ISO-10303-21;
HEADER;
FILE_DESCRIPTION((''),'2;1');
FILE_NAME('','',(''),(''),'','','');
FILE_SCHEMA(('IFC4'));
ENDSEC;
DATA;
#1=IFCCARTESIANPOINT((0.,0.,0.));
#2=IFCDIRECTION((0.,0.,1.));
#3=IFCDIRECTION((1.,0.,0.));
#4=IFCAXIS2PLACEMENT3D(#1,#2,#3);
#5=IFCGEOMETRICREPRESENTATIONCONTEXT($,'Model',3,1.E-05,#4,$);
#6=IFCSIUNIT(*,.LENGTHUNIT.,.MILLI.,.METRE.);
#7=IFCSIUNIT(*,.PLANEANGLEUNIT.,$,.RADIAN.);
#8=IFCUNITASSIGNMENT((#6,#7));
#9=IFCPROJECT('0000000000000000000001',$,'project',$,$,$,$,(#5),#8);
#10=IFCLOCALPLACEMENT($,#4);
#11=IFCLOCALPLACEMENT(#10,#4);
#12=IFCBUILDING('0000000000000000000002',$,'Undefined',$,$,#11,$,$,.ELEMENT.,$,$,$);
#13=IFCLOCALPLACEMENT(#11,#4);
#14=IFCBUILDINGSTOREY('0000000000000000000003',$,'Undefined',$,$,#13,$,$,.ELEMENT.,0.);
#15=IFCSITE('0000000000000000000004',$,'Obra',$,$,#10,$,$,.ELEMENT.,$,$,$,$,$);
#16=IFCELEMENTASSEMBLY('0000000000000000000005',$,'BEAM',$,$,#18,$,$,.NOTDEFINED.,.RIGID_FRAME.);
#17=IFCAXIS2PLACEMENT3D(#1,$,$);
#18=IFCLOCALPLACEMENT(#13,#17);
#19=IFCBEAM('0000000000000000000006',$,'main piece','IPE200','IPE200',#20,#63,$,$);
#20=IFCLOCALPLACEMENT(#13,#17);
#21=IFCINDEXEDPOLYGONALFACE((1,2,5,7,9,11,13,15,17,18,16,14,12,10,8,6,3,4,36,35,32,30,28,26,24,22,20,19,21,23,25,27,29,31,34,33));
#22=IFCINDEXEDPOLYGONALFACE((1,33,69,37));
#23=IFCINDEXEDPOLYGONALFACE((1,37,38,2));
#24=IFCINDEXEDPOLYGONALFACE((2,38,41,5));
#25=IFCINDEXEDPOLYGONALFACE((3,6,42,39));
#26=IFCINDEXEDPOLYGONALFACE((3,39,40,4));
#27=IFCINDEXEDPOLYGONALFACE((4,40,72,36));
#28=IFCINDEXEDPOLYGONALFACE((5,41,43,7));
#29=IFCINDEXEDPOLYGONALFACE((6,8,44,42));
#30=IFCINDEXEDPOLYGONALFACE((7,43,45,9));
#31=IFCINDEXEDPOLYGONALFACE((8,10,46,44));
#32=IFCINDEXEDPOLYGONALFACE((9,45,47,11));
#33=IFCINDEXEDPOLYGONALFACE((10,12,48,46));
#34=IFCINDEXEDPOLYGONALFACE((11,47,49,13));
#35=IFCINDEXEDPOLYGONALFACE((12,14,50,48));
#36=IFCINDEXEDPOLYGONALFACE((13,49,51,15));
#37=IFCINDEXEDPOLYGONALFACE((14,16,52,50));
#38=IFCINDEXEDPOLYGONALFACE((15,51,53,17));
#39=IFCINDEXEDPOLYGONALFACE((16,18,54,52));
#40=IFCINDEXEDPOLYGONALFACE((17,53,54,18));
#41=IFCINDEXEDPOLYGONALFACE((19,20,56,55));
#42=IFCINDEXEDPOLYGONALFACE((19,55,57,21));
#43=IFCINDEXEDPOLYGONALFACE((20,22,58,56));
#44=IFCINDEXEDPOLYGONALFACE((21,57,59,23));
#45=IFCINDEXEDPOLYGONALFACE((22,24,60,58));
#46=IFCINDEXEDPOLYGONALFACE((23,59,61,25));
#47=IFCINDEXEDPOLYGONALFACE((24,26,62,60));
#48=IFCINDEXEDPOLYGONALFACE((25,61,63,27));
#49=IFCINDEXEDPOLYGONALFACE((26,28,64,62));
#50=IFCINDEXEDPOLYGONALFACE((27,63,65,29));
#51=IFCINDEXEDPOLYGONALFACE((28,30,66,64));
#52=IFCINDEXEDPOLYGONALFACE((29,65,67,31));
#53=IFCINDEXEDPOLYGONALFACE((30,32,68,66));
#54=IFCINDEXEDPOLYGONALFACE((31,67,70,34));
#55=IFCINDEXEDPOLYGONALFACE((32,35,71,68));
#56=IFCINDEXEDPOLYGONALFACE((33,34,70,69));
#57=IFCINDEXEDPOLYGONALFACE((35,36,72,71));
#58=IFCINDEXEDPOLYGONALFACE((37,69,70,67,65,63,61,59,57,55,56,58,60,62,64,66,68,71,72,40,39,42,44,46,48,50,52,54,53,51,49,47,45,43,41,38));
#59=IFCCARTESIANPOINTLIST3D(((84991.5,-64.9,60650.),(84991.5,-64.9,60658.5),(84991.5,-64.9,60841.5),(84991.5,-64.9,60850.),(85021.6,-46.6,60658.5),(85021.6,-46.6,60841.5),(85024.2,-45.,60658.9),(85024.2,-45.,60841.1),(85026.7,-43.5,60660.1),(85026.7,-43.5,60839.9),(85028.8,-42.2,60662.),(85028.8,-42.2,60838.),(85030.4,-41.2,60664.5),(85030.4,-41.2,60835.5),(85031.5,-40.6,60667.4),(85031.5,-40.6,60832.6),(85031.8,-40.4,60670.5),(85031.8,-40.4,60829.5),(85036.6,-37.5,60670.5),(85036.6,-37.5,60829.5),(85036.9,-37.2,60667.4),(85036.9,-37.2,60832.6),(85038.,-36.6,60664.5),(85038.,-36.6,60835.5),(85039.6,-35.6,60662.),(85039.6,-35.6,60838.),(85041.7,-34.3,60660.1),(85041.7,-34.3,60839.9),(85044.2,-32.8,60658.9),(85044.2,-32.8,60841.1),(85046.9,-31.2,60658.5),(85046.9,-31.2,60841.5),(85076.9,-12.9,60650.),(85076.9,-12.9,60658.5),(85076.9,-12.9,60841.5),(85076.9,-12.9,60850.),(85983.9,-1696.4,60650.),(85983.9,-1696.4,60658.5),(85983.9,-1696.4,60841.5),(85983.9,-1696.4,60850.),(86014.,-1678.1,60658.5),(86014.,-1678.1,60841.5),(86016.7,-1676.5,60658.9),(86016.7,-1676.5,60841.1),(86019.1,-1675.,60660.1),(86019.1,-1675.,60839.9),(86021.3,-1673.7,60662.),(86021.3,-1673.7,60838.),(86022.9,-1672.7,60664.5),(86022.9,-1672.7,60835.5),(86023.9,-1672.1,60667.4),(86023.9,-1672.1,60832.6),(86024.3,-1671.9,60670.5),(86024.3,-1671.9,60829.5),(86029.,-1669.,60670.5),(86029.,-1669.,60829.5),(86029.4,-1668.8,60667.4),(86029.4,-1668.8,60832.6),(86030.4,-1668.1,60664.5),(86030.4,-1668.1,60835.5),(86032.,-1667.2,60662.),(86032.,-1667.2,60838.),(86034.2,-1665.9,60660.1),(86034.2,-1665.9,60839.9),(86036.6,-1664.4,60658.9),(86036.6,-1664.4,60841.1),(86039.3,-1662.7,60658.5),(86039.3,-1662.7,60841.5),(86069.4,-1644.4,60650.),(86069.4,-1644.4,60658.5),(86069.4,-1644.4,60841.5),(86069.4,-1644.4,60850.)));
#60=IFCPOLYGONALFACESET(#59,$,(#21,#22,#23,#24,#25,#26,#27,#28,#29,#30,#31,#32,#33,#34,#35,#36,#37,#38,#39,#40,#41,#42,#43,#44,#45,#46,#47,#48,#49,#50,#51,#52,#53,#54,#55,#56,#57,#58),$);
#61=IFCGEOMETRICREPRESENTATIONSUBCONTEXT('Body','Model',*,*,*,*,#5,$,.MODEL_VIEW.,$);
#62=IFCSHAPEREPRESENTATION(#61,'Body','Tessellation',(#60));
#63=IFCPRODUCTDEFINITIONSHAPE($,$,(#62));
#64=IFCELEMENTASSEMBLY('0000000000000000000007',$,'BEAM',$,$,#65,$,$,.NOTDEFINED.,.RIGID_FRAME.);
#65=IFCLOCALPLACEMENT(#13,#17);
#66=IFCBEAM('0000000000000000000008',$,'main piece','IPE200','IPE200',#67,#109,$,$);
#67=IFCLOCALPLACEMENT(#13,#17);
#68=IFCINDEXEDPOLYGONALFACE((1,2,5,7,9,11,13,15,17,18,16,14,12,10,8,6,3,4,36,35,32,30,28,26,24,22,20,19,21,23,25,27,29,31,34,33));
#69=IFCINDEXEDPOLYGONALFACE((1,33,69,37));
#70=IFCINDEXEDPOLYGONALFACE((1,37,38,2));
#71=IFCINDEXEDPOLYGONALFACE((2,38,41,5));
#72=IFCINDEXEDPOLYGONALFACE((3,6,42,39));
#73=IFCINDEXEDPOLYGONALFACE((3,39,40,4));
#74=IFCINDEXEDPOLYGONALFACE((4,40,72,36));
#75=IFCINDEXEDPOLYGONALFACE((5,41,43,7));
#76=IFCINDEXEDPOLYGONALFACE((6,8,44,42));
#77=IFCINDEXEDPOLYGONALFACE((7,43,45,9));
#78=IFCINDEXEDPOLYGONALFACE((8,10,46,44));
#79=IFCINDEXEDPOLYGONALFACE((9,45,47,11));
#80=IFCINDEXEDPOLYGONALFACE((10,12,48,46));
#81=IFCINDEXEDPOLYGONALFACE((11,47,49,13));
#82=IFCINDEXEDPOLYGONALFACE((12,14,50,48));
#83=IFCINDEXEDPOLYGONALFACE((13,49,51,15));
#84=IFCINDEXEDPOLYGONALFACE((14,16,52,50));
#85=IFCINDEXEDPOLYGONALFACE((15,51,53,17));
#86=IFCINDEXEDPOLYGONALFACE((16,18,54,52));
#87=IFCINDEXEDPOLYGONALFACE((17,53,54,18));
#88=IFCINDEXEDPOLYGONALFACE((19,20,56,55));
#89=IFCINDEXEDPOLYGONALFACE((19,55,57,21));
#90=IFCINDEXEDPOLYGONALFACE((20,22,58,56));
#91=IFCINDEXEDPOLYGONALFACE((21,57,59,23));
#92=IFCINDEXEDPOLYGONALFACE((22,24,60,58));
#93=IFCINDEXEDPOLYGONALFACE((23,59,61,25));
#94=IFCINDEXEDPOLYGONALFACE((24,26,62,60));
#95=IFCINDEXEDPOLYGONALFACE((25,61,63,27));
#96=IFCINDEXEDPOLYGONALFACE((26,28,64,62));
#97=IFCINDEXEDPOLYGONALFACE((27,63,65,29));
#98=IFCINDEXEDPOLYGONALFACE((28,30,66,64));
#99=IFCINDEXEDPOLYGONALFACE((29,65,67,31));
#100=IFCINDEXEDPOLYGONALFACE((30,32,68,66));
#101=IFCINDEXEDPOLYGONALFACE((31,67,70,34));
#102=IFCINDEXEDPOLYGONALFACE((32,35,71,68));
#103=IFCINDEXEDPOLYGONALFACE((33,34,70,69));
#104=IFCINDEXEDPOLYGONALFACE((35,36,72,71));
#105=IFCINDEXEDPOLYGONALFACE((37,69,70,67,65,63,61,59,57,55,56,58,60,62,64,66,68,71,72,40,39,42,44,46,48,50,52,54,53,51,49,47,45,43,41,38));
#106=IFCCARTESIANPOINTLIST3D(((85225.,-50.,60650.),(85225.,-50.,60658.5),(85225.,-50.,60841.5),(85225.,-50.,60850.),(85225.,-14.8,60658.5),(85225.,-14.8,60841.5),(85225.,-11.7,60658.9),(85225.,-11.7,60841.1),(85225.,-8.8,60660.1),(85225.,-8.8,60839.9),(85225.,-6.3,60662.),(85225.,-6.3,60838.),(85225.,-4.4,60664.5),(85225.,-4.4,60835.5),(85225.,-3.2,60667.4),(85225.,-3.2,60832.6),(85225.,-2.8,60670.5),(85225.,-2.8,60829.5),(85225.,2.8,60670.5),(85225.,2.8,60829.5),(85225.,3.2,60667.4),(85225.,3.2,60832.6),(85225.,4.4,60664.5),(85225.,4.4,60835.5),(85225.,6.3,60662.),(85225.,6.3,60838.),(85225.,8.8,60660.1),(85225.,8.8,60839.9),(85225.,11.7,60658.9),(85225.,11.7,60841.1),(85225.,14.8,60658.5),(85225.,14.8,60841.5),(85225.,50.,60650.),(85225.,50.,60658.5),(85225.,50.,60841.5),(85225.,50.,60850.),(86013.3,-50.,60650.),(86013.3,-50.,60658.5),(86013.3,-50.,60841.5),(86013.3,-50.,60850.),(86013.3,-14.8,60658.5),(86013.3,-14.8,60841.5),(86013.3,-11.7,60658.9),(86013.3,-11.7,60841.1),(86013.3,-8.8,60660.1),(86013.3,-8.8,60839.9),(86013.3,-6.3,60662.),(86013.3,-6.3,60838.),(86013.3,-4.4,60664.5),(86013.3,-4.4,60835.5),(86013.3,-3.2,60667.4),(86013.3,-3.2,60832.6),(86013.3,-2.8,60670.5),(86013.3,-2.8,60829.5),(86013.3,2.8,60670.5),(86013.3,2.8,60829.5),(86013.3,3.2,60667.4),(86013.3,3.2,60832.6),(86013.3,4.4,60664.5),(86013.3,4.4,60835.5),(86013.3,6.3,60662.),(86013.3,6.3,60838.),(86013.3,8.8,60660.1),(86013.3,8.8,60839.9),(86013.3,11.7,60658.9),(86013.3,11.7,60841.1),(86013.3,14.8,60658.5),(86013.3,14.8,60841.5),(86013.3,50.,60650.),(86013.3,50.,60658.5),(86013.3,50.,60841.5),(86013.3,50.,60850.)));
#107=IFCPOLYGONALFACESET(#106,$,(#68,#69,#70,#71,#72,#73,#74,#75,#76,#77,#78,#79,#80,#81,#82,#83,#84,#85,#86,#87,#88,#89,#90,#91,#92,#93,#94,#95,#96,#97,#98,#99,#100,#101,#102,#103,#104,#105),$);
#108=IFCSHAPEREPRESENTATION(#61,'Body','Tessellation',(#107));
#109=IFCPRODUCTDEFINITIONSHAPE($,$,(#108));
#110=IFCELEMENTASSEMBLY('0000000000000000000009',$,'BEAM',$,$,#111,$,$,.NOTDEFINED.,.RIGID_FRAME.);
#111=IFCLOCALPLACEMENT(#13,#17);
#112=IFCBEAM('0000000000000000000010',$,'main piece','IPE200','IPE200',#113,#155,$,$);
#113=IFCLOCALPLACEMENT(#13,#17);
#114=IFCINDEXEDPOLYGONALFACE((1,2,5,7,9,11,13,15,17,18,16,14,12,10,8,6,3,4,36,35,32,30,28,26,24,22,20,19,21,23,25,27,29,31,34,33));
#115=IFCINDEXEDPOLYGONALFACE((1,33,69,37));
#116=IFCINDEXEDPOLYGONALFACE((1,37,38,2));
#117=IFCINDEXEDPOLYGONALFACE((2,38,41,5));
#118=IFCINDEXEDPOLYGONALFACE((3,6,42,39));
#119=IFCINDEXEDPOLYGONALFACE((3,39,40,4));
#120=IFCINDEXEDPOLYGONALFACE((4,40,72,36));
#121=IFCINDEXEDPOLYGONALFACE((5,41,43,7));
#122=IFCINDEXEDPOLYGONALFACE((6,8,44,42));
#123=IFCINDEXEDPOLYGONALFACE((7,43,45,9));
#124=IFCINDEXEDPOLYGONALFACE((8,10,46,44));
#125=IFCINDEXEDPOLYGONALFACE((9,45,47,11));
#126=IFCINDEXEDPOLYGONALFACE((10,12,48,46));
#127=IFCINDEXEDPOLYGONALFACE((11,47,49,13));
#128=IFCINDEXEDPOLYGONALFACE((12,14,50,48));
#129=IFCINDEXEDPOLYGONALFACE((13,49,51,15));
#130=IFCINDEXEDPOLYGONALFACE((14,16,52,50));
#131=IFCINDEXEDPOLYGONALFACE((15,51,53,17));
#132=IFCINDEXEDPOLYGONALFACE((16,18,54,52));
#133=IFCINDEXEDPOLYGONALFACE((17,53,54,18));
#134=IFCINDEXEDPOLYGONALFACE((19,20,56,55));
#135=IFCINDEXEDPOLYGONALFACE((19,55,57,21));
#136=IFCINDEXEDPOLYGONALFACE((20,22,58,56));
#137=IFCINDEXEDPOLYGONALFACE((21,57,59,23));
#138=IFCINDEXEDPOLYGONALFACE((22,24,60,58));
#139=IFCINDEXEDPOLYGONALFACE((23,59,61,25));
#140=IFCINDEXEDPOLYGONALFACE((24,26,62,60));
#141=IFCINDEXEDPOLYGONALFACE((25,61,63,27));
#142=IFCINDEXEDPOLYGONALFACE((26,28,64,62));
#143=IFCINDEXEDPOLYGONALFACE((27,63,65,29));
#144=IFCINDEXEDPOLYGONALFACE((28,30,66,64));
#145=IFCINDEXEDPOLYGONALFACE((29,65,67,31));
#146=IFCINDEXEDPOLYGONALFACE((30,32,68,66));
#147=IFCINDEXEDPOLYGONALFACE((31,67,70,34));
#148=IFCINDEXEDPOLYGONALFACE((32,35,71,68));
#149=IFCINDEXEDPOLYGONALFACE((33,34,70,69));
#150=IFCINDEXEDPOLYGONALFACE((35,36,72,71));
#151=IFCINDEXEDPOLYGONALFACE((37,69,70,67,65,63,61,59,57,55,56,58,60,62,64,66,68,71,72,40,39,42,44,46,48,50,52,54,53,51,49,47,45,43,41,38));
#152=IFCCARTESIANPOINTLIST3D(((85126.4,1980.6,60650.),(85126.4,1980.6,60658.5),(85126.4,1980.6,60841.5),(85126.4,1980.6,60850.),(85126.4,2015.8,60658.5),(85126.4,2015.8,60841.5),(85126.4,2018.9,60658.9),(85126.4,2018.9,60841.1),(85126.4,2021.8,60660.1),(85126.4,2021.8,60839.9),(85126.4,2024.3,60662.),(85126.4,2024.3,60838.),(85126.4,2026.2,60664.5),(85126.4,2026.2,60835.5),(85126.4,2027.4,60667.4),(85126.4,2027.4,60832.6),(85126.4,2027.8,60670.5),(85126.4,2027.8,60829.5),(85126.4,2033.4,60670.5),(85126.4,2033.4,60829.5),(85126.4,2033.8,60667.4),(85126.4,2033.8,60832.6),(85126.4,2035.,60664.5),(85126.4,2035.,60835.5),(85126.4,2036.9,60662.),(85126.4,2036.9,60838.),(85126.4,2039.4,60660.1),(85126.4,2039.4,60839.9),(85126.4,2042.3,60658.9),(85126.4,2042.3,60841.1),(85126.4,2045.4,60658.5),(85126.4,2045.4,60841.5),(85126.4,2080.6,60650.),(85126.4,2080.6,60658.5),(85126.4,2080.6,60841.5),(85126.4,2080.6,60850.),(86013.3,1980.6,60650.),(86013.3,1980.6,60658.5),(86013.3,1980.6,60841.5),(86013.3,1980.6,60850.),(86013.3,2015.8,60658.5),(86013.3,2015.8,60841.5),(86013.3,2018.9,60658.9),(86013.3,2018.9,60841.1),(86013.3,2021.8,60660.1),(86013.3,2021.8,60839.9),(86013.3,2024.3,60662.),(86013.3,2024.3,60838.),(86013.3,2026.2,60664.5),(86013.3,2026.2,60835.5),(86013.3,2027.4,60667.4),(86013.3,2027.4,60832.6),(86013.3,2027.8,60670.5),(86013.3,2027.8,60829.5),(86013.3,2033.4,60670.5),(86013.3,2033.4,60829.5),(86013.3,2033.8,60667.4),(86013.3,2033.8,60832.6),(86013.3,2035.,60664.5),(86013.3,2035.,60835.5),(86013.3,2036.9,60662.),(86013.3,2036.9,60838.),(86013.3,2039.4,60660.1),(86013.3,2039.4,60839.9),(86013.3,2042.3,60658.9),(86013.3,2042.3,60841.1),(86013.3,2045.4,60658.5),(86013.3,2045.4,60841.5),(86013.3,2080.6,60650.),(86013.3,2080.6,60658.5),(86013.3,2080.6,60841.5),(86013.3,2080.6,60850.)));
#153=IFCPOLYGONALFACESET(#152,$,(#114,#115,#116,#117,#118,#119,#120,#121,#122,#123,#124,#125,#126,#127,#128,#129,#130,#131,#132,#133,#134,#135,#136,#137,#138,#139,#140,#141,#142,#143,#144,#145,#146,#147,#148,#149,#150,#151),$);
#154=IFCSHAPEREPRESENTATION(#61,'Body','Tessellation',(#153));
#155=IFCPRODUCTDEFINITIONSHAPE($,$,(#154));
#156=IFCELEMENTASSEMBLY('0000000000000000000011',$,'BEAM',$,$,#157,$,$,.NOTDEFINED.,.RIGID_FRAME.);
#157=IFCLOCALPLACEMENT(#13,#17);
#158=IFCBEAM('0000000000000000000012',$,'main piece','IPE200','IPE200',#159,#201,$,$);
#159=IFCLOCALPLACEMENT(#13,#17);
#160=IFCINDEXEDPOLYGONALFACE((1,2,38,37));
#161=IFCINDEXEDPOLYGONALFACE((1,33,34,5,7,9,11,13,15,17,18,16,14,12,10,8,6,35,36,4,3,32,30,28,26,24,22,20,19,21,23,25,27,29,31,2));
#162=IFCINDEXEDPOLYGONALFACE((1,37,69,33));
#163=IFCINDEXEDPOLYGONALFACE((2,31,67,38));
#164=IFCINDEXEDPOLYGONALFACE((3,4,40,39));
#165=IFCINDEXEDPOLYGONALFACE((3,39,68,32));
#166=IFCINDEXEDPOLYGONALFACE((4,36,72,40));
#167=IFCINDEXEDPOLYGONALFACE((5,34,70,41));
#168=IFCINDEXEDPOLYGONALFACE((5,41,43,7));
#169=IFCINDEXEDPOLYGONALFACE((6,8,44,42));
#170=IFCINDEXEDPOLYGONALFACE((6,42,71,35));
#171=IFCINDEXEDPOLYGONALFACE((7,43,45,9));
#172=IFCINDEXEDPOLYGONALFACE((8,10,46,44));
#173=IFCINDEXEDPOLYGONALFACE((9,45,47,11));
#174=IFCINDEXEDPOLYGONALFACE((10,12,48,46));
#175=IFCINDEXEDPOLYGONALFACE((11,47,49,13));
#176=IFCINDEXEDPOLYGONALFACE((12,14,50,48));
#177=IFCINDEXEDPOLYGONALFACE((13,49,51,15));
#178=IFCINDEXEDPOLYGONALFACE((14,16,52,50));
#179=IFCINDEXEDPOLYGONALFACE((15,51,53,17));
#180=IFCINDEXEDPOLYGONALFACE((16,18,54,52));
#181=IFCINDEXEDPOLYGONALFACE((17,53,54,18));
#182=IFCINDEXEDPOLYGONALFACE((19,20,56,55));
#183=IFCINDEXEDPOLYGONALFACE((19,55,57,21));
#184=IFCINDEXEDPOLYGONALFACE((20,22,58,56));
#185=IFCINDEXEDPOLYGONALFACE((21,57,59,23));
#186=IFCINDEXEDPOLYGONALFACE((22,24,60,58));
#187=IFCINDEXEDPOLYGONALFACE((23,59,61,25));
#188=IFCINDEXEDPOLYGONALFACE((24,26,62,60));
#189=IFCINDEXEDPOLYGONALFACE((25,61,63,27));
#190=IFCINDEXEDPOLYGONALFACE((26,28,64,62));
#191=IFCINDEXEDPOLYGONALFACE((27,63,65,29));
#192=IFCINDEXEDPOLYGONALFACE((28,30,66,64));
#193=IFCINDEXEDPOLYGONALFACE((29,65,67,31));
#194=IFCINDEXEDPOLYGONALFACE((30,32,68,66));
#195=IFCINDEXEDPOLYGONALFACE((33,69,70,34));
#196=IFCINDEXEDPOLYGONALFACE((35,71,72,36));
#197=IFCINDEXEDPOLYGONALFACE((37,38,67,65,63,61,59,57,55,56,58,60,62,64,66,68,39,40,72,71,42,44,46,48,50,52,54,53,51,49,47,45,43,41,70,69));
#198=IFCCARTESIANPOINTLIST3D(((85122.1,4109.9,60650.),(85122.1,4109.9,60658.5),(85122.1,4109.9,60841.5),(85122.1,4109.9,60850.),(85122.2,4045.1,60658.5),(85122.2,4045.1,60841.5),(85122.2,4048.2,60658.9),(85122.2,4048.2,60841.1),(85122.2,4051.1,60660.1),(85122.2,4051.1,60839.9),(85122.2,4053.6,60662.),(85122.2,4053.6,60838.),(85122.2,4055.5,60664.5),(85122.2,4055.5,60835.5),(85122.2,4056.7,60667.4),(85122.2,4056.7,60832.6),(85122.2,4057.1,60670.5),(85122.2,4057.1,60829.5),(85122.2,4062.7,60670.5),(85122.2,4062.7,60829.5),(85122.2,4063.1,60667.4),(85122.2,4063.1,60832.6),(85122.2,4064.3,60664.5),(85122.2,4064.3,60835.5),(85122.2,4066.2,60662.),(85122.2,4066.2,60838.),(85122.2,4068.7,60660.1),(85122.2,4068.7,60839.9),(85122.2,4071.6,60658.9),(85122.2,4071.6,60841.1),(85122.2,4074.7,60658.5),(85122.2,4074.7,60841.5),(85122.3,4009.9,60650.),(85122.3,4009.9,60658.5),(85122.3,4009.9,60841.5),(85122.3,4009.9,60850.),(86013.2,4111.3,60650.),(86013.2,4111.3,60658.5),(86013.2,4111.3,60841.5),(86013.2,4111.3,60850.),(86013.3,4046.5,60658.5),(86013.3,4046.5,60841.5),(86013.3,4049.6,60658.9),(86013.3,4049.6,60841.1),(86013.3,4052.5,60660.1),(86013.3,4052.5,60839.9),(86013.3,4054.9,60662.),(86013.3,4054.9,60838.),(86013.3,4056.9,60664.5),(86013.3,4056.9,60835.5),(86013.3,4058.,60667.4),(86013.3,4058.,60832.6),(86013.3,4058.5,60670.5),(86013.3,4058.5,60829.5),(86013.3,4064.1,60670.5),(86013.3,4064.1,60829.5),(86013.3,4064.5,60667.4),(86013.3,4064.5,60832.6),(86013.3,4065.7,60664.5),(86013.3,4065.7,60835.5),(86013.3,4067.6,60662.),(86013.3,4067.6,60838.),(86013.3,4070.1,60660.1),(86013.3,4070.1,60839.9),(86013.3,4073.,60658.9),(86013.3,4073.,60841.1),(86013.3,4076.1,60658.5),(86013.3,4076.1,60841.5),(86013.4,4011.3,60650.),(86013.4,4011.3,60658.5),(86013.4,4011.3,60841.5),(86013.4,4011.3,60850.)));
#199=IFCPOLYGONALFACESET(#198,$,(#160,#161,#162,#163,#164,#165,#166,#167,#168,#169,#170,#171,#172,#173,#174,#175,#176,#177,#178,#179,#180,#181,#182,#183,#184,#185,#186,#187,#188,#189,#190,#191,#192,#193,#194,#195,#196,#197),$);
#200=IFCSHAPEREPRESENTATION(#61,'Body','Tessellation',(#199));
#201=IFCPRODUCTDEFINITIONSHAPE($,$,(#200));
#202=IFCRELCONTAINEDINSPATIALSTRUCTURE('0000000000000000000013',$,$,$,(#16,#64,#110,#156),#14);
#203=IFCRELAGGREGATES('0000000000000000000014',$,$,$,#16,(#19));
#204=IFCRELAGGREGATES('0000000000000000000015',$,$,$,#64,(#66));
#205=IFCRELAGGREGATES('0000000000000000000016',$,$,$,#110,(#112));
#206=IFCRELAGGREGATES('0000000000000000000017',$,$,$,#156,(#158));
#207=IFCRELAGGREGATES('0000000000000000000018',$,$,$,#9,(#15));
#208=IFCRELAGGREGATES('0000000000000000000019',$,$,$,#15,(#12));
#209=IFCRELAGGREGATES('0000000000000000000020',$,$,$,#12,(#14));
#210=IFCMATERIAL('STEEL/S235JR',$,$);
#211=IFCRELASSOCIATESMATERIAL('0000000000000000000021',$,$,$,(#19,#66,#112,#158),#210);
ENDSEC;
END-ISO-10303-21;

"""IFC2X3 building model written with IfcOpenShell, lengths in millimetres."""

from ifc_helpers import new_model, si_unit, frame, origin_with_axes, origin_2d_with_axis, place, context, subcontext, project, spatial, i_section, extrude, material, element, aggregate, save


model = new_model("IFC2X3")

# Units and contexts
model_context = context("Model", 3, precision=1e-05, world=origin_with_axes())
body_context = subcontext(model_context, "Body", "Model", "MODEL_VIEW")
ifc_project = project(units=[si_unit("LENGTHUNIT", "METRE", prefix="MILLI"), si_unit("PLANEANGLEUNIT", "RADIAN")], contexts=[model_context])

# Site, building, storey
site_placement = place(None, origin_with_axes())
site = spatial("IfcSite", under=ifc_project, at=site_placement, Name="Obra", CompositionType="ELEMENT")
building_placement = place(site_placement, origin_with_axes())
building = spatial("IfcBuilding", under=site, at=building_placement, Name="Undefined", CompositionType="ELEMENT")
storey_placement = place(building_placement, origin_with_axes())
storey = spatial("IfcBuildingStorey", under=building, at=storey_placement, Name="Undefined", CompositionType="ELEMENT", Elevation=0.0)

# Shared definitions
ifc_material_1 = material(Name="STEEL/S235JR")

# Element assemblies, beams
assembly_1_placement = place(storey_placement, origin_with_axes())
assembly_1 = element("IfcElementAssembly", 1, at=assembly_1_placement, inside=storey, Name="BEAM", AssemblyPlace="NOTDEFINED", PredefinedType="RIGID_FRAME")
beam_1_placement = place(assembly_1_placement, frame((85034.2, -38.9, 60750.0), z_axis=(0.0, 0.0, 1.0), x_axis=(0.519695, -0.854352, 0.0)))
beam_1 = element("IfcBeam", 2, at=beam_1_placement, material=ifc_material_1, Name="main piece", Description="IPE200", ObjectType="IPE200", context=body_context, shape_type="SweptSolid", body=[
    extrude(i_section(OverallWidth=100.0, OverallDepth=200.0, WebThickness=5.6, FlangeThickness=8.5, FilletRadius=12.0, at=origin_2d_with_axis()), frame((1909.7, 0.0, 0.0), z_axis=(-1.0, 0.0, 0.0), x_axis=(0.0, -1.0, 0.0)), (0.0, 0.0, 1.0), 1909.7),
])
aggregate(assembly_1, [beam_1])
assembly_2_placement = place(storey_placement, origin_with_axes())
assembly_2 = element("IfcElementAssembly", 3, at=assembly_2_placement, inside=storey, Name="BEAM", AssemblyPlace="NOTDEFINED", PredefinedType="RIGID_FRAME")
beam_2_placement = place(assembly_2_placement, frame((85225.0, 0.0, 60750.0), z_axis=(0.0, 0.0, 1.0), x_axis=(1.0, 0.0, 0.0)))
beam_2 = element("IfcBeam", 4, at=beam_2_placement, material=ifc_material_1, Name="main piece", Description="IPE200", ObjectType="IPE200", context=body_context, shape_type="SweptSolid", body=[
    extrude(i_section(OverallWidth=100.0, OverallDepth=200.0, WebThickness=5.6, FlangeThickness=8.5, FilletRadius=12.0, at=origin_2d_with_axis()), frame((788.3, 0.0, 0.0), z_axis=(-1.0, 0.0, 0.0), x_axis=(0.0, -1.0, 0.0)), (0.0, 0.0, 1.0), 788.3),
])
aggregate(assembly_2, [beam_2])
assembly_3_placement = place(storey_placement, origin_with_axes())
assembly_3 = element("IfcElementAssembly", 5, at=assembly_3_placement, inside=storey, Name="BEAM", AssemblyPlace="NOTDEFINED", PredefinedType="RIGID_FRAME")
beam_3_placement = place(assembly_3_placement, frame((85126.4, 2030.6, 60750.0), z_axis=(0.0, 0.0, 1.0), x_axis=(1.0, 0.0, 0.0)))
beam_3 = element("IfcBeam", 6, at=beam_3_placement, material=ifc_material_1, Name="main piece", Description="IPE200", ObjectType="IPE200", context=body_context, shape_type="SweptSolid", body=[
    extrude(i_section(OverallWidth=100.0, OverallDepth=200.0, WebThickness=5.6, FlangeThickness=8.5, FilletRadius=12.0, at=origin_2d_with_axis()), frame((886.9, 0.0, 0.0), z_axis=(-1.0, 0.0, 0.0), x_axis=(0.0, -1.0, 0.0)), (0.0, 0.0, 1.0), 886.9),
])
aggregate(assembly_3, [beam_3])
assembly_4_placement = place(storey_placement, origin_with_axes())
assembly_4 = element("IfcElementAssembly", 7, at=assembly_4_placement, inside=storey, Name="BEAM", AssemblyPlace="NOTDEFINED", PredefinedType="RIGID_FRAME")
beam_4_placement = place(assembly_4_placement, frame((85122.2, 4059.9, 60750.0), z_axis=(0.0, 0.0, 1.0), x_axis=(0.999999, 0.001525, 0.0)))
beam_4 = element("IfcBeam", 8, at=beam_4_placement, material=ifc_material_1, Name="main piece", Description="IPE200", ObjectType="IPE200", context=body_context, shape_type="SweptSolid", body=[
    extrude(i_section(OverallWidth=100.0, OverallDepth=200.0, WebThickness=5.6, FlangeThickness=8.5, FilletRadius=12.0, at=origin_2d_with_axis()), frame((891.1, 0.0, 0.0), z_axis=(-1.0, 0.0, 0.0), x_axis=(0.0, -1.0, 0.0)), (0.0, 0.0, 1.0), 891.1),
])
aggregate(assembly_4, [beam_4])

save(model, "model.ifc")
